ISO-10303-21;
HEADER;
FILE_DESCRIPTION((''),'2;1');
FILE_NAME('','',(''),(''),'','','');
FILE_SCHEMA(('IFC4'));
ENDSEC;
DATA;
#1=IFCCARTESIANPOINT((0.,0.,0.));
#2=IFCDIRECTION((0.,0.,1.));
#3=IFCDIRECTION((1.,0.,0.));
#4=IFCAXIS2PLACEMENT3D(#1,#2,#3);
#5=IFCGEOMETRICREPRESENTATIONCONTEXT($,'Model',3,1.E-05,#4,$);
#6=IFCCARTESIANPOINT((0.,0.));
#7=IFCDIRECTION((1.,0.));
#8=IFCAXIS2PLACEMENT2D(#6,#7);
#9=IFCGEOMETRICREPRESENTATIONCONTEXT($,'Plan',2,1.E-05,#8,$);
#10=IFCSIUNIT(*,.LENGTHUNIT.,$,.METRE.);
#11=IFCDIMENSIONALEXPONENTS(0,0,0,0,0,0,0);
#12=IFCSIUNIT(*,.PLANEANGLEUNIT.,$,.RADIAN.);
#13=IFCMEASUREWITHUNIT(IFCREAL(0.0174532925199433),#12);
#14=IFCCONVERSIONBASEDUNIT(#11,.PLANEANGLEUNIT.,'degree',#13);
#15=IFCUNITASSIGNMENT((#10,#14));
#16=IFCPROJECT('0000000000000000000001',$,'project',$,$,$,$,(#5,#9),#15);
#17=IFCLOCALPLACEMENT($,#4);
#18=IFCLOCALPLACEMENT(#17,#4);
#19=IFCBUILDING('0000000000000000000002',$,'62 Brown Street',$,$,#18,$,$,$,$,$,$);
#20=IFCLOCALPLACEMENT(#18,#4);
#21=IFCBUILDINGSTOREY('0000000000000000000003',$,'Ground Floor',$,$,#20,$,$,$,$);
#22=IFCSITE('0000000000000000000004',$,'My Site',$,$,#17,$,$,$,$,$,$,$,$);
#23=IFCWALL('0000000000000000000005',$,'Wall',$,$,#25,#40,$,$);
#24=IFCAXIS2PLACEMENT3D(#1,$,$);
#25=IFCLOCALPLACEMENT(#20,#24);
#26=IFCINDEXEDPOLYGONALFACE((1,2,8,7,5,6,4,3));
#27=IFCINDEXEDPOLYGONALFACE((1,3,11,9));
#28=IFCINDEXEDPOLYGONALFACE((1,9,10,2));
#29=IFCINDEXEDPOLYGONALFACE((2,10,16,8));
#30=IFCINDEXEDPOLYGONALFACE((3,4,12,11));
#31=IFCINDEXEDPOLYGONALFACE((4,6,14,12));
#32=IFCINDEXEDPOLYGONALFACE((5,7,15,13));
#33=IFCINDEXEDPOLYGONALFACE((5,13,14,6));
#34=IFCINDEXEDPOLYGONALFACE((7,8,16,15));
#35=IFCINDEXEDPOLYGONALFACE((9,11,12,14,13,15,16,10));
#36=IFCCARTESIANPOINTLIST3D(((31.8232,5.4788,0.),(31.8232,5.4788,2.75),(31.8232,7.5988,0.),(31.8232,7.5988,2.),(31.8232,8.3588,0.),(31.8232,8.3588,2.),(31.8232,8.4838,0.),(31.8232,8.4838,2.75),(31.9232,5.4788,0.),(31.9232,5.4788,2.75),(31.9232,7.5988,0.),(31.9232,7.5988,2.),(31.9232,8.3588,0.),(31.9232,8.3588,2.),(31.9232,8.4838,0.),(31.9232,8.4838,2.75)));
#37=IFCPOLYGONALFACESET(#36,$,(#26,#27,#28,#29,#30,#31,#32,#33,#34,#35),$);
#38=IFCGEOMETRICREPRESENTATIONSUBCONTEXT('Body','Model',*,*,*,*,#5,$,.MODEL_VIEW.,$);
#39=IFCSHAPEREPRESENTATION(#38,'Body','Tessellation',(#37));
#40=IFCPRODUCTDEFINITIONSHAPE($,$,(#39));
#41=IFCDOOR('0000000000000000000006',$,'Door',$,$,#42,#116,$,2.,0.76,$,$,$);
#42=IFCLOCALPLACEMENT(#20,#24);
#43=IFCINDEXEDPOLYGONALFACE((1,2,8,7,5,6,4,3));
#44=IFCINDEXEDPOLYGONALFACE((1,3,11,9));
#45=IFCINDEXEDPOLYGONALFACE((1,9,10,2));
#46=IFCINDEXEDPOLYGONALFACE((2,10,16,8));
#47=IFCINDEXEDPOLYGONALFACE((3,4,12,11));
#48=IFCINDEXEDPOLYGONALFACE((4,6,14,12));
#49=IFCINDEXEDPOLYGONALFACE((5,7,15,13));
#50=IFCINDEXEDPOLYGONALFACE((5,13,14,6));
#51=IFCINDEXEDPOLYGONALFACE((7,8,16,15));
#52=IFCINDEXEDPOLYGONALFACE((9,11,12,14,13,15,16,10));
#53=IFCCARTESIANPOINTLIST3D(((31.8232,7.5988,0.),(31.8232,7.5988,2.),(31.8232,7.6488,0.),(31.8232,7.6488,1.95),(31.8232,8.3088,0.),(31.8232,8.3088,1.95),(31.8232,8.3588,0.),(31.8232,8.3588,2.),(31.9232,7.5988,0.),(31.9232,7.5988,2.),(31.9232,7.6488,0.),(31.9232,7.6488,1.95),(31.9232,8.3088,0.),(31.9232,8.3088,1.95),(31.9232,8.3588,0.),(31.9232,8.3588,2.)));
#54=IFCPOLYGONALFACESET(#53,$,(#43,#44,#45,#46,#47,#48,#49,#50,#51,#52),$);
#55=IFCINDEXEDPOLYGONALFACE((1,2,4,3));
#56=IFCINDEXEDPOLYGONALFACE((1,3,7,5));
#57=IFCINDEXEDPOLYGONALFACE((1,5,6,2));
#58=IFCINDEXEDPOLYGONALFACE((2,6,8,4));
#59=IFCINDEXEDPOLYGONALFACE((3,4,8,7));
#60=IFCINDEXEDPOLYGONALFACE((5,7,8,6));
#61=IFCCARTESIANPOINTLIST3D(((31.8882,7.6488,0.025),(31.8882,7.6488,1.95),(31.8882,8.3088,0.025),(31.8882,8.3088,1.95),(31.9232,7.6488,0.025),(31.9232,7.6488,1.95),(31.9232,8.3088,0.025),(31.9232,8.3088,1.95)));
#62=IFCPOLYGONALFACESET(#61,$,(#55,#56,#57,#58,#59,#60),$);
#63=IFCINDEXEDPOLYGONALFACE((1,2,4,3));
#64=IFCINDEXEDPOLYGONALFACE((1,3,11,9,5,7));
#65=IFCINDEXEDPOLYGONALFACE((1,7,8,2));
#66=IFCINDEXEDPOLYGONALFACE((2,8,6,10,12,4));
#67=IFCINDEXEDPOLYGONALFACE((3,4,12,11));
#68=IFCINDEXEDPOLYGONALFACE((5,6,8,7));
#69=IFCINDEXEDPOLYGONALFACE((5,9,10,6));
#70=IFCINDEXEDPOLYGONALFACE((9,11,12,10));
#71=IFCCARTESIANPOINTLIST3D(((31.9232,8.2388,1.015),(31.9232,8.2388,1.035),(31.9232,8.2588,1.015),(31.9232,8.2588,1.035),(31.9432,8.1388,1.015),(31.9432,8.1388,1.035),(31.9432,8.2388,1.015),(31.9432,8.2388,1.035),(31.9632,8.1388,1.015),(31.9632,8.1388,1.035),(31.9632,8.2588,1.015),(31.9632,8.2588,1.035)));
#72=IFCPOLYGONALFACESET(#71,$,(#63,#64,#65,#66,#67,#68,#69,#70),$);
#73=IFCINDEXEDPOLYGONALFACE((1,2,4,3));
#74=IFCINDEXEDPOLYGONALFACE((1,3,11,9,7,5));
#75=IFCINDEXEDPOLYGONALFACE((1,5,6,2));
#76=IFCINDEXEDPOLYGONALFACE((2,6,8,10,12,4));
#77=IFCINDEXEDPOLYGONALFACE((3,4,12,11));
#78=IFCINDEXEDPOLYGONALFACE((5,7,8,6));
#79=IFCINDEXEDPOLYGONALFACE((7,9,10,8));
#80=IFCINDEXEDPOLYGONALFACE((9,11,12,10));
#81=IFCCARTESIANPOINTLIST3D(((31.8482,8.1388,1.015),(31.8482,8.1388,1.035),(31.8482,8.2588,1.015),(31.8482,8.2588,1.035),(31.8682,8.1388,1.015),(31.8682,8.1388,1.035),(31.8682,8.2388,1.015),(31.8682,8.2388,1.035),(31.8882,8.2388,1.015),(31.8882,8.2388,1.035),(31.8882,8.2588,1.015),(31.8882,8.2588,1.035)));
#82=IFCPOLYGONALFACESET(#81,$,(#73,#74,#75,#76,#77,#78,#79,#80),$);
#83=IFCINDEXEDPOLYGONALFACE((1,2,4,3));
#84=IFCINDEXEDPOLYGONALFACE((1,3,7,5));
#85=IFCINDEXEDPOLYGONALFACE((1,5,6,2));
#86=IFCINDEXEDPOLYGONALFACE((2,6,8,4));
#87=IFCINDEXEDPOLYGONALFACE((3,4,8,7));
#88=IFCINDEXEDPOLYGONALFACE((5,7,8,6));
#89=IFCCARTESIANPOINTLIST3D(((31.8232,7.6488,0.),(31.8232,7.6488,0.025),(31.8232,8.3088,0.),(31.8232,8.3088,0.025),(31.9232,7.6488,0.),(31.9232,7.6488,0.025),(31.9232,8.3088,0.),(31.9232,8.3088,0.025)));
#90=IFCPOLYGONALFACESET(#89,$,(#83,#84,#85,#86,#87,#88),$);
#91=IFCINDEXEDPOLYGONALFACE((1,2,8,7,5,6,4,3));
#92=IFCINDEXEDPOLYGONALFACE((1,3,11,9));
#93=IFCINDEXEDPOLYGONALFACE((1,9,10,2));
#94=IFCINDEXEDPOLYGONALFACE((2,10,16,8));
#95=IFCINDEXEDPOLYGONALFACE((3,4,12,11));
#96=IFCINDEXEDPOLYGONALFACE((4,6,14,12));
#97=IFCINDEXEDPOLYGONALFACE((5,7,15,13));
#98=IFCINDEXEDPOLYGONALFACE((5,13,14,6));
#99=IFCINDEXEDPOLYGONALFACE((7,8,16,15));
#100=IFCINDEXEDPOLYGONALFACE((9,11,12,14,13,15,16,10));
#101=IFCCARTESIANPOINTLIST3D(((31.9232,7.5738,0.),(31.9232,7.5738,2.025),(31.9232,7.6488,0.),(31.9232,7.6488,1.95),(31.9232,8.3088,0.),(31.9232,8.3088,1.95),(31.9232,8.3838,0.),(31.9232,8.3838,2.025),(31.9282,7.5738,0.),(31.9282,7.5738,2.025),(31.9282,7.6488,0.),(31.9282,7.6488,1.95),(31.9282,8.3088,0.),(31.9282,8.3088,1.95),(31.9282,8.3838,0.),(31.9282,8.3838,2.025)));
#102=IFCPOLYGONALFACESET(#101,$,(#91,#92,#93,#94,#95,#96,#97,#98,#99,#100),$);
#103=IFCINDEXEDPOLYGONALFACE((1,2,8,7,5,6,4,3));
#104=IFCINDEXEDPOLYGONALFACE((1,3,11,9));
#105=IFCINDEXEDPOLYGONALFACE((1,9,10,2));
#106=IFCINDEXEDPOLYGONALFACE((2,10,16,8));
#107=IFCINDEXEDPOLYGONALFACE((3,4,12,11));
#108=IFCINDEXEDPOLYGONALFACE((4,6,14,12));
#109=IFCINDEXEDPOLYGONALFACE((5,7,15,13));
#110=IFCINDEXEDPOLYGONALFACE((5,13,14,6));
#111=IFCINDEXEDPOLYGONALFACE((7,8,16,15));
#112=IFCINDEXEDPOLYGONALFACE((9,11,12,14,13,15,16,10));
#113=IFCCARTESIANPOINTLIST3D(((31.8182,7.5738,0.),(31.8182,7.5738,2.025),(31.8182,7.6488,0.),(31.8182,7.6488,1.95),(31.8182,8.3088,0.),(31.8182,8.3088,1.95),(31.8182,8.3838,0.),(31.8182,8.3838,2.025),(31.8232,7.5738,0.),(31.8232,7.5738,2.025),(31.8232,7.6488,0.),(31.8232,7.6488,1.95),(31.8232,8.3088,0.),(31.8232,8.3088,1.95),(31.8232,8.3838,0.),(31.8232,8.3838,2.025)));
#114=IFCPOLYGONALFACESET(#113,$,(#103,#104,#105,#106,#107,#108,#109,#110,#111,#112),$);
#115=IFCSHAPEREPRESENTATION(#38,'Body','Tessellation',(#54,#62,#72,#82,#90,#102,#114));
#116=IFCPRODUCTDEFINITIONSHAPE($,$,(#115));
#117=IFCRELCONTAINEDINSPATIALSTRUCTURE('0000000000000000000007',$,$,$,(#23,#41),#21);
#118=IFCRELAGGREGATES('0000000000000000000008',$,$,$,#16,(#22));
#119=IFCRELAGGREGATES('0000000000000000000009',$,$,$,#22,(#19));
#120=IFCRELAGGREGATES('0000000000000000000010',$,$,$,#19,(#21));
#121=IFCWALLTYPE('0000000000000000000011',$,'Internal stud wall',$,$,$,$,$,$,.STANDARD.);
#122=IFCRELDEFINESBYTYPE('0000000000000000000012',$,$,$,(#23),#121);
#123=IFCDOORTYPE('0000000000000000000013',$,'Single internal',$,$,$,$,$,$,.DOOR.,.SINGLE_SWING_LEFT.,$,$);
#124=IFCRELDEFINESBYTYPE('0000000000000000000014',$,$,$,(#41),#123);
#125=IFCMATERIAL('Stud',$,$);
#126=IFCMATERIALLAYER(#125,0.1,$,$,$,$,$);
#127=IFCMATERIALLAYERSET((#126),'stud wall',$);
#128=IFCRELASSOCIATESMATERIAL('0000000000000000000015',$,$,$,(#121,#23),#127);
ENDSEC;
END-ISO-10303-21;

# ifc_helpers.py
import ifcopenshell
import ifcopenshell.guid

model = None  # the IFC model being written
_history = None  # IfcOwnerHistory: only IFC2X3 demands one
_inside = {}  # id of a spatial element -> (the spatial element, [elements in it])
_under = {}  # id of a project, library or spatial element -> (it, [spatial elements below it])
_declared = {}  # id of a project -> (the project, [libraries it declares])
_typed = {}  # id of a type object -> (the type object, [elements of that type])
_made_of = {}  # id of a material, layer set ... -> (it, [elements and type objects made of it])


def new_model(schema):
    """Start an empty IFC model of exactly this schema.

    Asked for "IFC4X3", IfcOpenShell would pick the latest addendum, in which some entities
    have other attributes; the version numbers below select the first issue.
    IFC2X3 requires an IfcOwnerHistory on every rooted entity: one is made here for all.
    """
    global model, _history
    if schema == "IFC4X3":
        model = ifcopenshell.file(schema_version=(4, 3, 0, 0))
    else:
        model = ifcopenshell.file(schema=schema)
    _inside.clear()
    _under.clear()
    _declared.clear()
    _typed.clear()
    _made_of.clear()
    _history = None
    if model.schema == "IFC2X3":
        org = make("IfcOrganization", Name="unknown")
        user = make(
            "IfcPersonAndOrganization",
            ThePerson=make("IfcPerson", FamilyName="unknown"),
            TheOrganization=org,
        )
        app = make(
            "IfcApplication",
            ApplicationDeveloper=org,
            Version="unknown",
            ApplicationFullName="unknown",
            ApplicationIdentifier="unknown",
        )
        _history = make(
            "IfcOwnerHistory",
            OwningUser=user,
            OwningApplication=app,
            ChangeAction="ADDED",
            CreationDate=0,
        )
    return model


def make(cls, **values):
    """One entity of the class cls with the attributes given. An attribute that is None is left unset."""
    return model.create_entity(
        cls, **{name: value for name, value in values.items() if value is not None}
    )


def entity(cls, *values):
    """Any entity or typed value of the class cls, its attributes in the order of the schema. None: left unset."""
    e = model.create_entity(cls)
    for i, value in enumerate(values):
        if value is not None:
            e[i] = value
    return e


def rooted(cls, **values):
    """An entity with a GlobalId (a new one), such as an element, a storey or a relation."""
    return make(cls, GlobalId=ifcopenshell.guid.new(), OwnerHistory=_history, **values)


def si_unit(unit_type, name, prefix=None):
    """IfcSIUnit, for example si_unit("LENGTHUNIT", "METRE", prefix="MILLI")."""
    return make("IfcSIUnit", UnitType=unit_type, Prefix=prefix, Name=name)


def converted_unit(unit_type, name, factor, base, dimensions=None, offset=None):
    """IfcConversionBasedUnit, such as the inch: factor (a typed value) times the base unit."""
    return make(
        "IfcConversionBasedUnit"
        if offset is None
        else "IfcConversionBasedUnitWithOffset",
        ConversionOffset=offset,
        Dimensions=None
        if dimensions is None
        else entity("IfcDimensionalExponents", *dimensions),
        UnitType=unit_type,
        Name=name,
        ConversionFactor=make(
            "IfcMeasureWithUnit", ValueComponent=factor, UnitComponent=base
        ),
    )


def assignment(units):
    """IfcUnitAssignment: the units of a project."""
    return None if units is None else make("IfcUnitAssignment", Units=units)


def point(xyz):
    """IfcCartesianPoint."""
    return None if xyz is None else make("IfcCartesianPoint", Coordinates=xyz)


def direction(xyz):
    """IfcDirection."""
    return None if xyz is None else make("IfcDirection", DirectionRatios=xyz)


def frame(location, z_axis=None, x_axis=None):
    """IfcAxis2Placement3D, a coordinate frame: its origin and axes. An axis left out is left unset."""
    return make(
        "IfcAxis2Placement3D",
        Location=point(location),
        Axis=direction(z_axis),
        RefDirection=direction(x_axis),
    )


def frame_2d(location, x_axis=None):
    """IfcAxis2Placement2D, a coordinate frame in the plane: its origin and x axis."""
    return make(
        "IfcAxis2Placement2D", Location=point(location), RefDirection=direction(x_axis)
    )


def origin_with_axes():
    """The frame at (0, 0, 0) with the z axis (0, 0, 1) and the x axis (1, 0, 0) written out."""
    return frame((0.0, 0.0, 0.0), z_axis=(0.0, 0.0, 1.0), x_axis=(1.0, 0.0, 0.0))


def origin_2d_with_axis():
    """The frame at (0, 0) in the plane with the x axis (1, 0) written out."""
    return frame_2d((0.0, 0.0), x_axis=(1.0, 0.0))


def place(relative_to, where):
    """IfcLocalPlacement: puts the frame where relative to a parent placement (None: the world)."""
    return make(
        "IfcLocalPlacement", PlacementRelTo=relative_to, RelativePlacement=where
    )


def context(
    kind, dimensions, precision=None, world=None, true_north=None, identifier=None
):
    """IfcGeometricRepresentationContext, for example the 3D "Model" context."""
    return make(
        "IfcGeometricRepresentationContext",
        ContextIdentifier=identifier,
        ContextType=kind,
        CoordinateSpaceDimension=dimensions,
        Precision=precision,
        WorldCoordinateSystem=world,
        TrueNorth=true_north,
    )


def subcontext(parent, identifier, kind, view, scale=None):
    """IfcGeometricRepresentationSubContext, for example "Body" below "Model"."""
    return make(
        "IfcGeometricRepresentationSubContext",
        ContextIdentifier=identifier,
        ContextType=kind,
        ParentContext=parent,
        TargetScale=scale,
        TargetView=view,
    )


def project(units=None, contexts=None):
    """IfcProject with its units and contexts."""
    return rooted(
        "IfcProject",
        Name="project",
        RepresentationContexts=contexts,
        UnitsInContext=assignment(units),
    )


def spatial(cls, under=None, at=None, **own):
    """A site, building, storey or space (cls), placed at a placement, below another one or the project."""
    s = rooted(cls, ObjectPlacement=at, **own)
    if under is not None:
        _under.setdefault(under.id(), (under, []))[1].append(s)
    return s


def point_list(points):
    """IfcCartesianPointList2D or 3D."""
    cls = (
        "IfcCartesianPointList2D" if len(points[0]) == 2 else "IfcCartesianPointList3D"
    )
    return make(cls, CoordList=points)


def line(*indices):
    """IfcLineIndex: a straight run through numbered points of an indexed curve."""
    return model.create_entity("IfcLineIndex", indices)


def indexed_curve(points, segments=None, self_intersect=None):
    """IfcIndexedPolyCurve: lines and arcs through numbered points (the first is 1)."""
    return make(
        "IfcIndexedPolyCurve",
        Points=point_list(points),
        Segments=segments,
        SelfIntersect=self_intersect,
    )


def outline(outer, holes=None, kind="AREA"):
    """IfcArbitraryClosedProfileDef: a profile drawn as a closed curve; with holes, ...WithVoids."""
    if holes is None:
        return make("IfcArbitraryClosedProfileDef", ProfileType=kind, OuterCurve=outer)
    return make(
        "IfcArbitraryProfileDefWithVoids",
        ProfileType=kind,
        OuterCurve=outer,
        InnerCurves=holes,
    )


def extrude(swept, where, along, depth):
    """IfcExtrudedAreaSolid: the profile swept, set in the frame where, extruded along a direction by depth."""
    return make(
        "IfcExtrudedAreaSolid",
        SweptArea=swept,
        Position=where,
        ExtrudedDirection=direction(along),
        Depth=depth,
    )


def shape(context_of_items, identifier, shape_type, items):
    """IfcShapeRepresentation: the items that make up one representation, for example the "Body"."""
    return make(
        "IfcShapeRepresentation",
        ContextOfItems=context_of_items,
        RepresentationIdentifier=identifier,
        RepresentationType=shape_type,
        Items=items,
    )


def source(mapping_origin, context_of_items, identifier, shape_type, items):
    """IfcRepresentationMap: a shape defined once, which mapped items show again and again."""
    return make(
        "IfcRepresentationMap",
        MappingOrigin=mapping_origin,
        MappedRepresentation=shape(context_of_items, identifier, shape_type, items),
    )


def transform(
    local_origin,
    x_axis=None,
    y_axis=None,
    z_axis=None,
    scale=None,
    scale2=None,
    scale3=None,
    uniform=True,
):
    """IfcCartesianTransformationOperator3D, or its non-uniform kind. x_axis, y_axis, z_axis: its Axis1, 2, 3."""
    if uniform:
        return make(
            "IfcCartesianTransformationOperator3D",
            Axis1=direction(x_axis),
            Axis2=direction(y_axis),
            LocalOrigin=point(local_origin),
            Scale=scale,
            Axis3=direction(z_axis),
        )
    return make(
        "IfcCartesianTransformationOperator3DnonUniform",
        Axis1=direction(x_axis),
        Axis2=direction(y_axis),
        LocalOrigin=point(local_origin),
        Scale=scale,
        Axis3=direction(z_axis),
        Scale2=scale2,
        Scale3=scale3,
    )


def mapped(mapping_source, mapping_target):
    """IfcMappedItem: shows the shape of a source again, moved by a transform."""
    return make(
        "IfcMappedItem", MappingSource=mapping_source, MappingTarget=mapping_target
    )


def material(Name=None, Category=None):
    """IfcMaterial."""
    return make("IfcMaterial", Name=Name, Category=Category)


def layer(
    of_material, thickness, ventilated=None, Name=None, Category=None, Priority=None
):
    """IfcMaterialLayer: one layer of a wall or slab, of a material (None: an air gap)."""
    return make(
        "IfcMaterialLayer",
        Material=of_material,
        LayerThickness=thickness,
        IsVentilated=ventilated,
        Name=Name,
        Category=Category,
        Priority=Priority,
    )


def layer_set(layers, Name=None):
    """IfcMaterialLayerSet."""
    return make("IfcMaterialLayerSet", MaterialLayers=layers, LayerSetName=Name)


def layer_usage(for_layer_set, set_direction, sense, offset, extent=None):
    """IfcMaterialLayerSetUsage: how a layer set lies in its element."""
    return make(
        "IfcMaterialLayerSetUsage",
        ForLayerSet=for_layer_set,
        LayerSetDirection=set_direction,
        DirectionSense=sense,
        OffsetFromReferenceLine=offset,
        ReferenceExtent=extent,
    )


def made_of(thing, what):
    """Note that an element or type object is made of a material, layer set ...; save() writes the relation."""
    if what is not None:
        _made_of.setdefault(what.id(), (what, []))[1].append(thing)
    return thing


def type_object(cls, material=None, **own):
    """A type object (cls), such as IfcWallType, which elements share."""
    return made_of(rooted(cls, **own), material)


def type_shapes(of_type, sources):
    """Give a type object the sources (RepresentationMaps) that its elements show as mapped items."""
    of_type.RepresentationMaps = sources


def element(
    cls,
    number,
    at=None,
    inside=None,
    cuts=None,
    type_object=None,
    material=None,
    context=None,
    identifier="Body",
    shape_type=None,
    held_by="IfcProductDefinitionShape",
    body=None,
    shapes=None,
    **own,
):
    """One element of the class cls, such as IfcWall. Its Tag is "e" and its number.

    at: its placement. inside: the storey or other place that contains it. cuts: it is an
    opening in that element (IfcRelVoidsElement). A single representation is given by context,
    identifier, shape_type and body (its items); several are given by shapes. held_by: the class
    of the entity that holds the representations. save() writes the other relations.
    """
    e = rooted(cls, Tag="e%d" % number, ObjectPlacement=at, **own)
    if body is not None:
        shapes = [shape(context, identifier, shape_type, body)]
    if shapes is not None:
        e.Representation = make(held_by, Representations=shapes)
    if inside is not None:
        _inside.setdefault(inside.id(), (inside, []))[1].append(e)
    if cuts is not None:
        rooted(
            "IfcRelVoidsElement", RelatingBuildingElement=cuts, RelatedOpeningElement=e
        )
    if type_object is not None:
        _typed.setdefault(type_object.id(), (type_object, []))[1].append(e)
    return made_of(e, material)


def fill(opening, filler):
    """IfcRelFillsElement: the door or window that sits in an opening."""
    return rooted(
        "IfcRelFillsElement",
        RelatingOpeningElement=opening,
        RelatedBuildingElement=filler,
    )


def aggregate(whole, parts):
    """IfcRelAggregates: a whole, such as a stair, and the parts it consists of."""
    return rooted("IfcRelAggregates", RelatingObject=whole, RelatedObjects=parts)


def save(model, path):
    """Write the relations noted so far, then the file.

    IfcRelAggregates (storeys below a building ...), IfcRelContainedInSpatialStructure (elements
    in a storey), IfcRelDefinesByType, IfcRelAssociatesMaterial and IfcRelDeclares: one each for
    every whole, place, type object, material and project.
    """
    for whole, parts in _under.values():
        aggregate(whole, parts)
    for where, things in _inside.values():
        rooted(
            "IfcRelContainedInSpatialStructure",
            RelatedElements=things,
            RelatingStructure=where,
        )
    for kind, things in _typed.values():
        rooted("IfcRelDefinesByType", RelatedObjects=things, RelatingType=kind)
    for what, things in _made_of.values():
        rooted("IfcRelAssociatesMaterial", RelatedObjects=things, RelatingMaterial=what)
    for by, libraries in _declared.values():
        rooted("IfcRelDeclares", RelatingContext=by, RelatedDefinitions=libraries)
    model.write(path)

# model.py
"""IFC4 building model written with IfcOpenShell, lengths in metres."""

from ifc_helpers import new_model, entity, si_unit, converted_unit, frame, origin_with_axes, origin_2d_with_axis, place, context, subcontext, project, spatial, line, indexed_curve, outline, extrude, shape, source, transform, mapped, material, layer, layer_set, layer_usage, type_object, type_shapes, element, fill, save


model = new_model("IFC4")

# Units and contexts
model_context = context("Model", 3, precision=1e-05, world=origin_with_axes())
plan_context = context("Plan", 2, precision=1e-05, world=origin_2d_with_axis())
body_context_1 = subcontext(model_context, "Body", "Model", "MODEL_VIEW")
body_context_2 = subcontext(plan_context, "Body", "Plan", "PLAN_VIEW")
ifc_project = project(units=[si_unit("LENGTHUNIT", "METRE"), converted_unit("PLANEANGLEUNIT", "degree", entity("IfcReal", 0.0174532925199433), si_unit("PLANEANGLEUNIT", "RADIAN"), dimensions=[0, 0, 0, 0, 0, 0, 0])], contexts=[model_context, plan_context])

# Site, building, storey
site_placement = place(None, origin_with_axes())
site = spatial("IfcSite", under=ifc_project, at=site_placement, Name="My Site")
building_placement = place(site_placement, origin_with_axes())
building = spatial("IfcBuilding", under=site, at=building_placement, Name="62 Brown Street")
storey_placement = place(building_placement, origin_with_axes())
storey = spatial("IfcBuildingStorey", under=building, at=storey_placement, Name="Ground Floor")

# Wall, opening, door
ifc_material_1 = material(Name="Stud")
ifc_layer_1 = layer(ifc_material_1, 0.1)
ifc_layer_set_1 = layer_set([ifc_layer_1], Name="stud wall")
wall_type_1 = type_object("IfcWallType", Name="Internal stud wall", PredefinedType="STANDARD", material=ifc_layer_set_1)
shared_shape_1 = source(origin_with_axes(), body_context_1, "Body", "SweptSolid", [
    extrude(outline(indexed_curve([(0.0, 0.0), (0.76, 0.0), (0.76, 2.0), (0.0, 2.0)], segments=[line(1, 2, 3, 4, 1)])), frame((0.0, -0.6, 0.0), z_axis=(0.0, -1.0, 0.0), x_axis=(1.0, 0.0, 0.0)), (0.0, 0.0, -1.0), 1.2),
])
door_type_1 = type_object("IfcDoorType", Name="Single internal", OperationType="SINGLE_SWING_LEFT", PredefinedType="DOOR")
shared_shape_2 = source(origin_with_axes(), body_context_1, "Body", "SweptSolid", [
    extrude(outline(indexed_curve([(0.0, 0.0), (0.0, 2.0), (0.76, 2.0), (0.76, 0.0), (0.71, 0.0), (0.71, 1.95), (0.05, 1.95), (0.05, 0.0)], segments=[line(1, 2, 3, 4, 5, 6, 7, 8, 1)])), frame((0.0, 0.0, 0.0), z_axis=(0.0, -1.0, 0.0), x_axis=(1.0, 0.0, 0.0)), (0.0, 0.0, -1.0), 0.1),
    extrude(outline(indexed_curve([(0.0, 0.0), (0.66, 0.0), (0.66, 0.035), (0.0, 0.035)], segments=[line(1, 2, 3, 4, 1)])), frame((0.05, 0.0, 0.025), z_axis=(0.0, 0.0, 1.0), x_axis=(1.0, 0.0, 0.0)), (0.0, 0.0, 1.0), 1.925),
    extrude(outline(indexed_curve([(0.0, 0.0), (0.0, -0.04), (-0.12, -0.04), (-0.12, -0.02), (-0.02, -0.02), (-0.02, 0.0)], segments=[line(1, 2, 3, 4, 5, 6, 1)])), frame((0.66, 0.0, 1.015), z_axis=(0.0, 0.0, 1.0), x_axis=(1.0, 0.0, 0.0)), (0.0, 0.0, 1.0), 0.02),
    extrude(outline(indexed_curve([(0.0, 0.0), (0.0, 0.04), (-0.12, 0.04), (-0.12, 0.02), (-0.02, 0.02), (-0.02, 0.0)], segments=[line(1, 2, 3, 4, 5, 6, 1)])), frame((0.66, 0.035, 1.015), z_axis=(0.0, 0.0, 1.0), x_axis=(1.0, 0.0, 0.0)), (0.0, 0.0, 1.0), 0.02),
    extrude(outline(indexed_curve([(0.0, 0.0), (0.66, 0.0), (0.66, 0.1), (0.0, 0.1)], segments=[line(1, 2, 3, 4, 1)])), frame((0.05, 0.0, 0.0), z_axis=(0.0, 0.0, 1.0), x_axis=(1.0, 0.0, 0.0)), (0.0, 0.0, 1.0), 0.025),
    extrude(outline(indexed_curve([(0.0, 0.0), (0.0, 2.025), (0.81, 2.025), (0.81, 0.0), (0.735, 0.0), (0.735, 1.95), (0.075, 1.95), (0.075, 0.0)], segments=[line(1, 2, 3, 4, 5, 6, 7, 8, 1)])), frame((-0.025, -0.005, 0.0), z_axis=(0.0, -1.0, 0.0), x_axis=(1.0, 0.0, 0.0)), (0.0, 0.0, -1.0), 0.005),
    extrude(outline(indexed_curve([(0.0, 0.0), (0.0, 2.025), (0.81, 2.025), (0.81, 0.0), (0.735, 0.0), (0.735, 1.95), (0.075, 1.95), (0.075, 0.0)], segments=[line(1, 2, 3, 4, 5, 6, 7, 8, 1)])), frame((-0.025, 0.1, 0.0), z_axis=(0.0, -1.0, 0.0), x_axis=(1.0, 0.0, 0.0)), (0.0, 0.0, -1.0), 0.005),
])
shared_shape_3 = source(origin_with_axes(), body_context_2, "Body", "Curve2D", [
    entity("IfcIndexedPolyCurve", entity("IfcCartesianPointList2D", [[0.0, 0.0], [0.05, 0.0], [0.05, 0.1], [0.0, 0.1]]), [entity("IfcLineIndex", [1, 2, 3, 4, 1])]),
    entity("IfcIndexedPolyCurve", entity("IfcCartesianPointList2D", [[0.76, 0.0], [0.71, 0.0], [0.71, 0.1], [0.76, 0.1]]), [entity("IfcLineIndex", [1, 2, 3, 4, 1])]),
    entity("IfcTrimmedCurve", entity("IfcEllipse", entity("IfcAxis2Placement2D", entity("IfcCartesianPoint", [0.085, 0.1]), entity("IfcDirection", [1.0, 0.0])), 0.625, 0.66), [entity("IfcCartesianPoint", [0.71, 0.1])], [entity("IfcCartesianPoint", [0.085, 0.76])], True, "CARTESIAN"),
    entity("IfcIndexedPolyCurve", entity("IfcCartesianPointList2D", [[0.05, 0.1], [0.085, 0.1], [0.085, 0.76], [0.05, 0.76]]), [entity("IfcLineIndex", [1, 2, 3, 4, 1])]),
])
type_shapes(door_type_1, [shared_shape_2, shared_shape_3])
ifc_layer_usage_1 = layer_usage(ifc_layer_set_1, "AXIS2", "POSITIVE", 0.0)
wall_1_placement = place(storey_placement, frame((31.9232, 5.4788, 0.0), z_axis=(0.0, 0.0, 1.0), x_axis=(0.000001, 1.0, 0.0)))
wall_1 = element("IfcWall", 1, at=wall_1_placement, inside=storey, type_object=wall_type_1, material=ifc_layer_usage_1, Name="Wall", context=body_context_1, shape_type="SweptSolid", body=[
    extrude(outline(indexed_curve([(0.0, 0.0), (0.0, 0.1), (3.005, 0.1), (3.005, 0.0), (0.0, 0.0)], self_intersect=False)), origin_with_axes(), (0.0, 0.0, 1.0), 2.75),
])
opening_1_placement = place(wall_1_placement, frame((2.12, 0.0, 0.0), z_axis=(0.0, 0.0, 1.0), x_axis=(1.0, 0.0, 0.0)))
opening_1 = element("IfcOpeningElement", 2, at=opening_1_placement, cuts=wall_1, PredefinedType="OPENING", context=body_context_1, shape_type="MappedRepresentation", body=[
    mapped(shared_shape_1, transform((0.0, 0.0, 0.0), x_axis=(1.0, 0.0, 0.0), y_axis=(0.0, 1.0, 0.0), z_axis=(0.0, 0.0, 1.0), scale=1.0)),
])
door_1_placement = place(opening_1_placement, frame((0.0, 0.0, 0.0), z_axis=(0.0, 0.0, 1.0), x_axis=(1.0, 0.0, 0.0)))
door_1 = element("IfcDoor", 3, at=door_1_placement, inside=storey, type_object=door_type_1, Name="Door", OverallHeight=2.0, OverallWidth=0.76, shapes=[
    shape(body_context_1, "Body", "MappedRepresentation", [mapped(shared_shape_2, transform((0.0, 0.0, 0.0), x_axis=(1.0, 0.0, 0.0), y_axis=(0.0, 1.0, 0.0), z_axis=(0.0, 0.0, 1.0), scale=1.0))]),
    shape(body_context_2, "Body", "MappedRepresentation", [mapped(shared_shape_3, transform((0.0, 0.0, 0.0), x_axis=(1.0, 0.0, 0.0), y_axis=(0.0, 1.0, 0.0), z_axis=(0.0, 0.0, 1.0), scale=1.0))]),
])
fill(opening_1, door_1)

save(model, "model.ifc")
